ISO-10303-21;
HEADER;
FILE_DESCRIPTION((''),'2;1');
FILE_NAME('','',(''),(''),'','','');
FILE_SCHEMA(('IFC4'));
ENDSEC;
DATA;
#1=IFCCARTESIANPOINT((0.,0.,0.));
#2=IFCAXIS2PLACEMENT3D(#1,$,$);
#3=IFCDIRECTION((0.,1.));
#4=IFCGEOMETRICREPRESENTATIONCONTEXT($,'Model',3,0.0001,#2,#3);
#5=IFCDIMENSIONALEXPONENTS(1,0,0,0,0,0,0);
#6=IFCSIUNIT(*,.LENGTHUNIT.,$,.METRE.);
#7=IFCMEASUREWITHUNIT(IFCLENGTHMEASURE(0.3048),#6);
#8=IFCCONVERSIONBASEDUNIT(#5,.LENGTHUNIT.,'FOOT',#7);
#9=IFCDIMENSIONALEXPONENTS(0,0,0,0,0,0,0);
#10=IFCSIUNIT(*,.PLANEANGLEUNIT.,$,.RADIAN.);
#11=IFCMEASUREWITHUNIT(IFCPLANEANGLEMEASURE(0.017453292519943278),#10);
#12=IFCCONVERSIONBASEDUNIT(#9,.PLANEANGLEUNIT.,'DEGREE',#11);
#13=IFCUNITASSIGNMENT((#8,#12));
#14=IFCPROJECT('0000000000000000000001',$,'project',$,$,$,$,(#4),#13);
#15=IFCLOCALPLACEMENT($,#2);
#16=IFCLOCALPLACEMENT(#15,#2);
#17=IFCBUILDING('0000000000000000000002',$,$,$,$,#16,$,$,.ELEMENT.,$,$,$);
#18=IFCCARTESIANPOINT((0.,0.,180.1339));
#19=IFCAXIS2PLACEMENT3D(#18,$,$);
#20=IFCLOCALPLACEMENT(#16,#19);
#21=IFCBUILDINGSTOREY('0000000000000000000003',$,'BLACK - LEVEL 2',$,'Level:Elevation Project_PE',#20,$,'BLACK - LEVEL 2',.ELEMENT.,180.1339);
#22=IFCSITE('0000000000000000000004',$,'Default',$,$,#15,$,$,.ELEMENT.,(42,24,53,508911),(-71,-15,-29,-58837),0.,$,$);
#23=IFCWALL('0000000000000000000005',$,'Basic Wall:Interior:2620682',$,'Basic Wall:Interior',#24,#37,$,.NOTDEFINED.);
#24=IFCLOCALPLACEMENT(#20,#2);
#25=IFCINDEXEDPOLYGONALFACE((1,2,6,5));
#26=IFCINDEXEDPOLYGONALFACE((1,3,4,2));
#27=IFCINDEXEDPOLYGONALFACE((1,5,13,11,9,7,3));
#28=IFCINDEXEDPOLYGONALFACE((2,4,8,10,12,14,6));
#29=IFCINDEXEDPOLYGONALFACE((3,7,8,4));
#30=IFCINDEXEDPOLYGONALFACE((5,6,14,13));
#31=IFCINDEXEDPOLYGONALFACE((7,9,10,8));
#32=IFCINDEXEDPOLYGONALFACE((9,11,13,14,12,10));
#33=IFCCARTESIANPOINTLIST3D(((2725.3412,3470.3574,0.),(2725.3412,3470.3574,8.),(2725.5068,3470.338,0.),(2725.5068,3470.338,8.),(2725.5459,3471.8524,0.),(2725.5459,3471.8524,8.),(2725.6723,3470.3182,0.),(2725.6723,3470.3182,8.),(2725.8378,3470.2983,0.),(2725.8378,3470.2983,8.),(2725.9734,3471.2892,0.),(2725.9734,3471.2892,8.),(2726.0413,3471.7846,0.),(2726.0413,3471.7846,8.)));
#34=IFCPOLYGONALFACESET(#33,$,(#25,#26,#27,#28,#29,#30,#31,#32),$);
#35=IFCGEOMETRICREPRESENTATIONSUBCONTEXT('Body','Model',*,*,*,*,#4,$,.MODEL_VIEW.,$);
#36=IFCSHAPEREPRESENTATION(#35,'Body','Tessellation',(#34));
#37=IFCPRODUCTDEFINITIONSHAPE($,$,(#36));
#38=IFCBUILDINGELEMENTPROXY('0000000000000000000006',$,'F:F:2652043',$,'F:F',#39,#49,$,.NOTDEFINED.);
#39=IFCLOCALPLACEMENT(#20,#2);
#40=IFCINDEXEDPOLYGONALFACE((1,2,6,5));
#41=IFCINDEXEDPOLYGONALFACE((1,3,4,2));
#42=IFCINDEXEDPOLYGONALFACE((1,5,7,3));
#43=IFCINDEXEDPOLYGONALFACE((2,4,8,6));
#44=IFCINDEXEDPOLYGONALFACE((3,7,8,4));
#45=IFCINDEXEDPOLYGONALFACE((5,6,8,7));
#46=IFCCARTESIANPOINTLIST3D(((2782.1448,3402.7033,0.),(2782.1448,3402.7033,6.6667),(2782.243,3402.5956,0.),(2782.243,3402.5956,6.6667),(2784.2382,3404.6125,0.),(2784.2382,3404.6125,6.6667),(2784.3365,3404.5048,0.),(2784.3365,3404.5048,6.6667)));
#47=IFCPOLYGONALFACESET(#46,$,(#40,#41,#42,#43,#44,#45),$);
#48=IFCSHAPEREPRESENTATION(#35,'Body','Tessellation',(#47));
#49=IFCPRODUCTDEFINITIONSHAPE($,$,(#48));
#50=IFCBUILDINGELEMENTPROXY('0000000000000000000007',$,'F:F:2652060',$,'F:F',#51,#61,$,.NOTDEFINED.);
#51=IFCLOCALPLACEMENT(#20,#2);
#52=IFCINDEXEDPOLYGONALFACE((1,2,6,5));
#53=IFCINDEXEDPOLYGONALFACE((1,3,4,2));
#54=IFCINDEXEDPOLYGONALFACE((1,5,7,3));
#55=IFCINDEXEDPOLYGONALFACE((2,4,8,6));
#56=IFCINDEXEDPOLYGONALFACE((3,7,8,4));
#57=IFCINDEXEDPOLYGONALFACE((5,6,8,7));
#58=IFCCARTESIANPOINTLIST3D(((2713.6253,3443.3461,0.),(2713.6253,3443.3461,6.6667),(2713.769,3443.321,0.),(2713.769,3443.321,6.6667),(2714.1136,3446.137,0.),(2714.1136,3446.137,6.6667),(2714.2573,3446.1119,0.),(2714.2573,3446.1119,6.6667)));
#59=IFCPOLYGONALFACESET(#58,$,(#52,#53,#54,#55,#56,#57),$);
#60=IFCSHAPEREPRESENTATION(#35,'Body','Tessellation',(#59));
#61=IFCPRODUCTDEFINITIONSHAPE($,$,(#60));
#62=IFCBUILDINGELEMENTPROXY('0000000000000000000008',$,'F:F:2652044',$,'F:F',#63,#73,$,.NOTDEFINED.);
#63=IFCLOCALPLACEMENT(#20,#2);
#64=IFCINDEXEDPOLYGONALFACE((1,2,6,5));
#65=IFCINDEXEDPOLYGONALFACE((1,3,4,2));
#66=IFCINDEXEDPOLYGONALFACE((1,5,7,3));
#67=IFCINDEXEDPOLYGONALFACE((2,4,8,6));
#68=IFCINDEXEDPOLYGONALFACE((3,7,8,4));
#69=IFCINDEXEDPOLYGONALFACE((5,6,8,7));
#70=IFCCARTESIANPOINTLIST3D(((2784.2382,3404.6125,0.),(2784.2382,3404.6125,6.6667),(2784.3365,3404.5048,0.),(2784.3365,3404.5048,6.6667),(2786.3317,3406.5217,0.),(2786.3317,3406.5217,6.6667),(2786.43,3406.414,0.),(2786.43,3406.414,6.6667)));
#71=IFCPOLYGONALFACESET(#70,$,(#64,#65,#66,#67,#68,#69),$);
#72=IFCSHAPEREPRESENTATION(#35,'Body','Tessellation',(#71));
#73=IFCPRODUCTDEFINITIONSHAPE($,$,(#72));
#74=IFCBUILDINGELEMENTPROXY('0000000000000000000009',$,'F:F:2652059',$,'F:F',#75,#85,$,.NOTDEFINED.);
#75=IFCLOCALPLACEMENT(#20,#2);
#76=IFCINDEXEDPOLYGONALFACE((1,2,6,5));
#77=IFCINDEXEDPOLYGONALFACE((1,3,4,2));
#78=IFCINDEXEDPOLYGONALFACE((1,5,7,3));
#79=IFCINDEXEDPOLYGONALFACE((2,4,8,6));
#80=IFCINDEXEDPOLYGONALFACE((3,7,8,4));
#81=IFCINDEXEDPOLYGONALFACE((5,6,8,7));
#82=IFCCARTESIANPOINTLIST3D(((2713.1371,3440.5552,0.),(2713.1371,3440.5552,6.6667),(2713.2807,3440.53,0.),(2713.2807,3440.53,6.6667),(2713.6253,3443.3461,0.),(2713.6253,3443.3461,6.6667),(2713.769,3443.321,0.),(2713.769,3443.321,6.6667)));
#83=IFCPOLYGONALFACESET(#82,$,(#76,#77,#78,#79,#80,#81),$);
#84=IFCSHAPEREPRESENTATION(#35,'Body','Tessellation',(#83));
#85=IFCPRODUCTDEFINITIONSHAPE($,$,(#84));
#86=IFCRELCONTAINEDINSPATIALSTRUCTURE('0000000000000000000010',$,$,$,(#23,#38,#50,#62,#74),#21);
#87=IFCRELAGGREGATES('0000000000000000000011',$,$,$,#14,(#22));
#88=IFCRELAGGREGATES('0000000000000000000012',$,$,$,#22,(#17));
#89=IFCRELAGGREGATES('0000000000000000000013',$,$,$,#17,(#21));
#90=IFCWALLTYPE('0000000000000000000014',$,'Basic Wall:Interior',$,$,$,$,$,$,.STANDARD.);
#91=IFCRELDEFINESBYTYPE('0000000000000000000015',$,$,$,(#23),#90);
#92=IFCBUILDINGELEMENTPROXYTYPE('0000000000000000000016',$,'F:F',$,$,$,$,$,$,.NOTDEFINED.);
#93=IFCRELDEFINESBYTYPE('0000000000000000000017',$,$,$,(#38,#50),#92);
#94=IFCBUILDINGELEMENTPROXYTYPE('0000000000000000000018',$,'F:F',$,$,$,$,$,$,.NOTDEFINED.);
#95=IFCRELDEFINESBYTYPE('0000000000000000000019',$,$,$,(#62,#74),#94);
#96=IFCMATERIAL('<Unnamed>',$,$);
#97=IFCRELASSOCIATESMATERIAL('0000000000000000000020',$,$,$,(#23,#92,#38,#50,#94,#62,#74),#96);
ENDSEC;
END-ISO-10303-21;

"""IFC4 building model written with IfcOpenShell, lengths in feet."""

from ifc_helpers import new_model, entity, si_unit, converted_unit, direction, frame, origin, place, context, subcontext, project, spatial, line, arc, indexed_curve, outline, extrude, source, transform, mapped, material, type_object, type_shapes, element, save


model = new_model("IFC4")

# Units and contexts
model_context = context("Model", 3, precision=0.0001, world=origin(), true_north=direction((0.0, 1.0)))
body_context = subcontext(model_context, "Body", "Model", "MODEL_VIEW")
ifc_project = project(units=[converted_unit("LENGTHUNIT", "FOOT", entity("IfcLengthMeasure", 0.3048), si_unit("LENGTHUNIT", "METRE"), dimensions=[1, 0, 0, 0, 0, 0, 0]), converted_unit("PLANEANGLEUNIT", "DEGREE", entity("IfcPlaneAngleMeasure", 0.017453292519943278), si_unit("PLANEANGLEUNIT", "RADIAN"), dimensions=[0, 0, 0, 0, 0, 0, 0])], contexts=[model_context])

# Site, building, storey
site_placement = place(None, origin())
site = spatial("IfcSite", under=ifc_project, at=site_placement, Name="Default", CompositionType="ELEMENT", RefLatitude=(42, 24, 53, 508911), RefLongitude=(-71, -15, -29, -58837), RefElevation=0.0)
building_placement = place(site_placement, origin())
building = spatial("IfcBuilding", under=site, at=building_placement, CompositionType="ELEMENT")
storey_placement = place(building_placement, frame((0.0, 0.0, 180.1339)))
storey = spatial("IfcBuildingStorey", under=building, at=storey_placement, Name="BLACK - LEVEL 2", ObjectType="Level:Elevation Project_PE", LongName="BLACK - LEVEL 2", CompositionType="ELEMENT", Elevation=180.1339)

# Wall
ifc_material = material(Name="<Unnamed>")
wall_type = type_object("IfcWallType", Name="Basic Wall:Interior", PredefinedType="STANDARD")
wall_1_placement = place(storey_placement, frame((2725.5889, 3470.3235, 0.0), z_axis=(0.0, 0.0, 1.0), x_axis=(0.13564, 0.990758, 0.0)))
element("IfcWall", 1, at=wall_1_placement, inside=storey, type_object=wall_type, material=ifc_material, Name="Basic Wall:Interior:2620682", ObjectType="Basic Wall:Interior", PredefinedType="NOTDEFINED", context=body_context, shape_type="SweptSolid", body=[
    extrude(outline(indexed_curve([(1.5089, -0.25), (1.5089, 0.25), (0.0, 0.25), (0.0046, 0.0), (0.0087, -0.25), (1.0089, -0.25)], segments=[line(1, 2, 3), arc(3, 4, 5), line(5, 6, 1)], self_intersect=False)), origin(), (0.0, 0.0, 1.0), 8.0),
])

# Building element proxies
building_element_proxy_type_1 = type_object("IfcBuildingElementProxyType", Name="F:F", PredefinedType="NOTDEFINED", material=ifc_material)
shared_shape_1 = source(origin(), body_context, "Body", "SweptSolid", [
    extrude(outline(indexed_curve([(-0.0729, -1.4167), (0.0729, -1.4167), (0.0729, 1.4167), (-0.0729, 1.4167), (-0.0729, -1.4167)], self_intersect=False)), frame((-0.2859, 3.25, 0.0), z_axis=(0.0, 0.0, 1.0), x_axis=(0.0, 1.0, 0.0)), (0.0, 0.0, 1.0), 6.6667),
])
type_shapes(building_element_proxy_type_1, [shared_shape_1])
for number, where, z_axis, x_axis, name in (
    (2, (2780.8394, 3405.8128, 0.0), (0.0, 0.0, 1.0), (-0.738879, -0.673838, 0.0), "F:F:2652043"),
    (3, (2717.192, 3444.4505, 0.0), (0.0, 0.0, 1.0), (0.172334, 0.985039, 0.0), "F:F:2652060"),
):
    element("IfcBuildingElementProxy", number, at=place(storey_placement, frame(where, z_axis=z_axis, x_axis=x_axis)), inside=storey, type_object=building_element_proxy_type_1, material=ifc_material, Name=name, ObjectType="F:F", PredefinedType="NOTDEFINED", context=body_context, shape_type="MappedRepresentation", body=[
        mapped(shared_shape_1, transform((0.0, 0.0, 0.0), scale=1.0)),
    ])
building_element_proxy_type_2 = type_object("IfcBuildingElementProxyType", Name="F:F", PredefinedType="NOTDEFINED", material=ifc_material)
shared_shape_2 = source(origin(), body_context, "Body", "SweptSolid", [
    extrude(outline(indexed_curve([(-1.4167, -0.0729), (1.4167, -0.0729), (1.4167, 0.0729), (-1.4167, 0.0729), (-1.4167, -0.0729)], self_intersect=False)), frame((-0.2859, -3.25, 0.0), z_axis=(0.0, 0.0, 1.0), x_axis=(-1.0, 0.0, 0.0)), (0.0, 0.0, 1.0), 6.6667),
])
type_shapes(building_element_proxy_type_2, [shared_shape_2])
for number, where, z_axis, x_axis, name in (
    (4, (2783.3554, 3408.1073, 0.0), (0.0, 0.0, 1.0), (0.738879, 0.673838, 0.0), "F:F:2652044"),
    (5, (2716.6051, 3441.0964, 0.0), (0.0, 0.0, 1.0), (-0.172334, -0.985039, 0.0), "F:F:2652059"),
):
    element("IfcBuildingElementProxy", number, at=place(storey_placement, frame(where, z_axis=z_axis, x_axis=x_axis)), inside=storey, type_object=building_element_proxy_type_2, material=ifc_material, Name=name, ObjectType="F:F", PredefinedType="NOTDEFINED", context=body_context, shape_type="MappedRepresentation", body=[
        mapped(shared_shape_2, transform((0.0, 0.0, 0.0), scale=1.0)),
    ])

save(model, "model.ifc")
